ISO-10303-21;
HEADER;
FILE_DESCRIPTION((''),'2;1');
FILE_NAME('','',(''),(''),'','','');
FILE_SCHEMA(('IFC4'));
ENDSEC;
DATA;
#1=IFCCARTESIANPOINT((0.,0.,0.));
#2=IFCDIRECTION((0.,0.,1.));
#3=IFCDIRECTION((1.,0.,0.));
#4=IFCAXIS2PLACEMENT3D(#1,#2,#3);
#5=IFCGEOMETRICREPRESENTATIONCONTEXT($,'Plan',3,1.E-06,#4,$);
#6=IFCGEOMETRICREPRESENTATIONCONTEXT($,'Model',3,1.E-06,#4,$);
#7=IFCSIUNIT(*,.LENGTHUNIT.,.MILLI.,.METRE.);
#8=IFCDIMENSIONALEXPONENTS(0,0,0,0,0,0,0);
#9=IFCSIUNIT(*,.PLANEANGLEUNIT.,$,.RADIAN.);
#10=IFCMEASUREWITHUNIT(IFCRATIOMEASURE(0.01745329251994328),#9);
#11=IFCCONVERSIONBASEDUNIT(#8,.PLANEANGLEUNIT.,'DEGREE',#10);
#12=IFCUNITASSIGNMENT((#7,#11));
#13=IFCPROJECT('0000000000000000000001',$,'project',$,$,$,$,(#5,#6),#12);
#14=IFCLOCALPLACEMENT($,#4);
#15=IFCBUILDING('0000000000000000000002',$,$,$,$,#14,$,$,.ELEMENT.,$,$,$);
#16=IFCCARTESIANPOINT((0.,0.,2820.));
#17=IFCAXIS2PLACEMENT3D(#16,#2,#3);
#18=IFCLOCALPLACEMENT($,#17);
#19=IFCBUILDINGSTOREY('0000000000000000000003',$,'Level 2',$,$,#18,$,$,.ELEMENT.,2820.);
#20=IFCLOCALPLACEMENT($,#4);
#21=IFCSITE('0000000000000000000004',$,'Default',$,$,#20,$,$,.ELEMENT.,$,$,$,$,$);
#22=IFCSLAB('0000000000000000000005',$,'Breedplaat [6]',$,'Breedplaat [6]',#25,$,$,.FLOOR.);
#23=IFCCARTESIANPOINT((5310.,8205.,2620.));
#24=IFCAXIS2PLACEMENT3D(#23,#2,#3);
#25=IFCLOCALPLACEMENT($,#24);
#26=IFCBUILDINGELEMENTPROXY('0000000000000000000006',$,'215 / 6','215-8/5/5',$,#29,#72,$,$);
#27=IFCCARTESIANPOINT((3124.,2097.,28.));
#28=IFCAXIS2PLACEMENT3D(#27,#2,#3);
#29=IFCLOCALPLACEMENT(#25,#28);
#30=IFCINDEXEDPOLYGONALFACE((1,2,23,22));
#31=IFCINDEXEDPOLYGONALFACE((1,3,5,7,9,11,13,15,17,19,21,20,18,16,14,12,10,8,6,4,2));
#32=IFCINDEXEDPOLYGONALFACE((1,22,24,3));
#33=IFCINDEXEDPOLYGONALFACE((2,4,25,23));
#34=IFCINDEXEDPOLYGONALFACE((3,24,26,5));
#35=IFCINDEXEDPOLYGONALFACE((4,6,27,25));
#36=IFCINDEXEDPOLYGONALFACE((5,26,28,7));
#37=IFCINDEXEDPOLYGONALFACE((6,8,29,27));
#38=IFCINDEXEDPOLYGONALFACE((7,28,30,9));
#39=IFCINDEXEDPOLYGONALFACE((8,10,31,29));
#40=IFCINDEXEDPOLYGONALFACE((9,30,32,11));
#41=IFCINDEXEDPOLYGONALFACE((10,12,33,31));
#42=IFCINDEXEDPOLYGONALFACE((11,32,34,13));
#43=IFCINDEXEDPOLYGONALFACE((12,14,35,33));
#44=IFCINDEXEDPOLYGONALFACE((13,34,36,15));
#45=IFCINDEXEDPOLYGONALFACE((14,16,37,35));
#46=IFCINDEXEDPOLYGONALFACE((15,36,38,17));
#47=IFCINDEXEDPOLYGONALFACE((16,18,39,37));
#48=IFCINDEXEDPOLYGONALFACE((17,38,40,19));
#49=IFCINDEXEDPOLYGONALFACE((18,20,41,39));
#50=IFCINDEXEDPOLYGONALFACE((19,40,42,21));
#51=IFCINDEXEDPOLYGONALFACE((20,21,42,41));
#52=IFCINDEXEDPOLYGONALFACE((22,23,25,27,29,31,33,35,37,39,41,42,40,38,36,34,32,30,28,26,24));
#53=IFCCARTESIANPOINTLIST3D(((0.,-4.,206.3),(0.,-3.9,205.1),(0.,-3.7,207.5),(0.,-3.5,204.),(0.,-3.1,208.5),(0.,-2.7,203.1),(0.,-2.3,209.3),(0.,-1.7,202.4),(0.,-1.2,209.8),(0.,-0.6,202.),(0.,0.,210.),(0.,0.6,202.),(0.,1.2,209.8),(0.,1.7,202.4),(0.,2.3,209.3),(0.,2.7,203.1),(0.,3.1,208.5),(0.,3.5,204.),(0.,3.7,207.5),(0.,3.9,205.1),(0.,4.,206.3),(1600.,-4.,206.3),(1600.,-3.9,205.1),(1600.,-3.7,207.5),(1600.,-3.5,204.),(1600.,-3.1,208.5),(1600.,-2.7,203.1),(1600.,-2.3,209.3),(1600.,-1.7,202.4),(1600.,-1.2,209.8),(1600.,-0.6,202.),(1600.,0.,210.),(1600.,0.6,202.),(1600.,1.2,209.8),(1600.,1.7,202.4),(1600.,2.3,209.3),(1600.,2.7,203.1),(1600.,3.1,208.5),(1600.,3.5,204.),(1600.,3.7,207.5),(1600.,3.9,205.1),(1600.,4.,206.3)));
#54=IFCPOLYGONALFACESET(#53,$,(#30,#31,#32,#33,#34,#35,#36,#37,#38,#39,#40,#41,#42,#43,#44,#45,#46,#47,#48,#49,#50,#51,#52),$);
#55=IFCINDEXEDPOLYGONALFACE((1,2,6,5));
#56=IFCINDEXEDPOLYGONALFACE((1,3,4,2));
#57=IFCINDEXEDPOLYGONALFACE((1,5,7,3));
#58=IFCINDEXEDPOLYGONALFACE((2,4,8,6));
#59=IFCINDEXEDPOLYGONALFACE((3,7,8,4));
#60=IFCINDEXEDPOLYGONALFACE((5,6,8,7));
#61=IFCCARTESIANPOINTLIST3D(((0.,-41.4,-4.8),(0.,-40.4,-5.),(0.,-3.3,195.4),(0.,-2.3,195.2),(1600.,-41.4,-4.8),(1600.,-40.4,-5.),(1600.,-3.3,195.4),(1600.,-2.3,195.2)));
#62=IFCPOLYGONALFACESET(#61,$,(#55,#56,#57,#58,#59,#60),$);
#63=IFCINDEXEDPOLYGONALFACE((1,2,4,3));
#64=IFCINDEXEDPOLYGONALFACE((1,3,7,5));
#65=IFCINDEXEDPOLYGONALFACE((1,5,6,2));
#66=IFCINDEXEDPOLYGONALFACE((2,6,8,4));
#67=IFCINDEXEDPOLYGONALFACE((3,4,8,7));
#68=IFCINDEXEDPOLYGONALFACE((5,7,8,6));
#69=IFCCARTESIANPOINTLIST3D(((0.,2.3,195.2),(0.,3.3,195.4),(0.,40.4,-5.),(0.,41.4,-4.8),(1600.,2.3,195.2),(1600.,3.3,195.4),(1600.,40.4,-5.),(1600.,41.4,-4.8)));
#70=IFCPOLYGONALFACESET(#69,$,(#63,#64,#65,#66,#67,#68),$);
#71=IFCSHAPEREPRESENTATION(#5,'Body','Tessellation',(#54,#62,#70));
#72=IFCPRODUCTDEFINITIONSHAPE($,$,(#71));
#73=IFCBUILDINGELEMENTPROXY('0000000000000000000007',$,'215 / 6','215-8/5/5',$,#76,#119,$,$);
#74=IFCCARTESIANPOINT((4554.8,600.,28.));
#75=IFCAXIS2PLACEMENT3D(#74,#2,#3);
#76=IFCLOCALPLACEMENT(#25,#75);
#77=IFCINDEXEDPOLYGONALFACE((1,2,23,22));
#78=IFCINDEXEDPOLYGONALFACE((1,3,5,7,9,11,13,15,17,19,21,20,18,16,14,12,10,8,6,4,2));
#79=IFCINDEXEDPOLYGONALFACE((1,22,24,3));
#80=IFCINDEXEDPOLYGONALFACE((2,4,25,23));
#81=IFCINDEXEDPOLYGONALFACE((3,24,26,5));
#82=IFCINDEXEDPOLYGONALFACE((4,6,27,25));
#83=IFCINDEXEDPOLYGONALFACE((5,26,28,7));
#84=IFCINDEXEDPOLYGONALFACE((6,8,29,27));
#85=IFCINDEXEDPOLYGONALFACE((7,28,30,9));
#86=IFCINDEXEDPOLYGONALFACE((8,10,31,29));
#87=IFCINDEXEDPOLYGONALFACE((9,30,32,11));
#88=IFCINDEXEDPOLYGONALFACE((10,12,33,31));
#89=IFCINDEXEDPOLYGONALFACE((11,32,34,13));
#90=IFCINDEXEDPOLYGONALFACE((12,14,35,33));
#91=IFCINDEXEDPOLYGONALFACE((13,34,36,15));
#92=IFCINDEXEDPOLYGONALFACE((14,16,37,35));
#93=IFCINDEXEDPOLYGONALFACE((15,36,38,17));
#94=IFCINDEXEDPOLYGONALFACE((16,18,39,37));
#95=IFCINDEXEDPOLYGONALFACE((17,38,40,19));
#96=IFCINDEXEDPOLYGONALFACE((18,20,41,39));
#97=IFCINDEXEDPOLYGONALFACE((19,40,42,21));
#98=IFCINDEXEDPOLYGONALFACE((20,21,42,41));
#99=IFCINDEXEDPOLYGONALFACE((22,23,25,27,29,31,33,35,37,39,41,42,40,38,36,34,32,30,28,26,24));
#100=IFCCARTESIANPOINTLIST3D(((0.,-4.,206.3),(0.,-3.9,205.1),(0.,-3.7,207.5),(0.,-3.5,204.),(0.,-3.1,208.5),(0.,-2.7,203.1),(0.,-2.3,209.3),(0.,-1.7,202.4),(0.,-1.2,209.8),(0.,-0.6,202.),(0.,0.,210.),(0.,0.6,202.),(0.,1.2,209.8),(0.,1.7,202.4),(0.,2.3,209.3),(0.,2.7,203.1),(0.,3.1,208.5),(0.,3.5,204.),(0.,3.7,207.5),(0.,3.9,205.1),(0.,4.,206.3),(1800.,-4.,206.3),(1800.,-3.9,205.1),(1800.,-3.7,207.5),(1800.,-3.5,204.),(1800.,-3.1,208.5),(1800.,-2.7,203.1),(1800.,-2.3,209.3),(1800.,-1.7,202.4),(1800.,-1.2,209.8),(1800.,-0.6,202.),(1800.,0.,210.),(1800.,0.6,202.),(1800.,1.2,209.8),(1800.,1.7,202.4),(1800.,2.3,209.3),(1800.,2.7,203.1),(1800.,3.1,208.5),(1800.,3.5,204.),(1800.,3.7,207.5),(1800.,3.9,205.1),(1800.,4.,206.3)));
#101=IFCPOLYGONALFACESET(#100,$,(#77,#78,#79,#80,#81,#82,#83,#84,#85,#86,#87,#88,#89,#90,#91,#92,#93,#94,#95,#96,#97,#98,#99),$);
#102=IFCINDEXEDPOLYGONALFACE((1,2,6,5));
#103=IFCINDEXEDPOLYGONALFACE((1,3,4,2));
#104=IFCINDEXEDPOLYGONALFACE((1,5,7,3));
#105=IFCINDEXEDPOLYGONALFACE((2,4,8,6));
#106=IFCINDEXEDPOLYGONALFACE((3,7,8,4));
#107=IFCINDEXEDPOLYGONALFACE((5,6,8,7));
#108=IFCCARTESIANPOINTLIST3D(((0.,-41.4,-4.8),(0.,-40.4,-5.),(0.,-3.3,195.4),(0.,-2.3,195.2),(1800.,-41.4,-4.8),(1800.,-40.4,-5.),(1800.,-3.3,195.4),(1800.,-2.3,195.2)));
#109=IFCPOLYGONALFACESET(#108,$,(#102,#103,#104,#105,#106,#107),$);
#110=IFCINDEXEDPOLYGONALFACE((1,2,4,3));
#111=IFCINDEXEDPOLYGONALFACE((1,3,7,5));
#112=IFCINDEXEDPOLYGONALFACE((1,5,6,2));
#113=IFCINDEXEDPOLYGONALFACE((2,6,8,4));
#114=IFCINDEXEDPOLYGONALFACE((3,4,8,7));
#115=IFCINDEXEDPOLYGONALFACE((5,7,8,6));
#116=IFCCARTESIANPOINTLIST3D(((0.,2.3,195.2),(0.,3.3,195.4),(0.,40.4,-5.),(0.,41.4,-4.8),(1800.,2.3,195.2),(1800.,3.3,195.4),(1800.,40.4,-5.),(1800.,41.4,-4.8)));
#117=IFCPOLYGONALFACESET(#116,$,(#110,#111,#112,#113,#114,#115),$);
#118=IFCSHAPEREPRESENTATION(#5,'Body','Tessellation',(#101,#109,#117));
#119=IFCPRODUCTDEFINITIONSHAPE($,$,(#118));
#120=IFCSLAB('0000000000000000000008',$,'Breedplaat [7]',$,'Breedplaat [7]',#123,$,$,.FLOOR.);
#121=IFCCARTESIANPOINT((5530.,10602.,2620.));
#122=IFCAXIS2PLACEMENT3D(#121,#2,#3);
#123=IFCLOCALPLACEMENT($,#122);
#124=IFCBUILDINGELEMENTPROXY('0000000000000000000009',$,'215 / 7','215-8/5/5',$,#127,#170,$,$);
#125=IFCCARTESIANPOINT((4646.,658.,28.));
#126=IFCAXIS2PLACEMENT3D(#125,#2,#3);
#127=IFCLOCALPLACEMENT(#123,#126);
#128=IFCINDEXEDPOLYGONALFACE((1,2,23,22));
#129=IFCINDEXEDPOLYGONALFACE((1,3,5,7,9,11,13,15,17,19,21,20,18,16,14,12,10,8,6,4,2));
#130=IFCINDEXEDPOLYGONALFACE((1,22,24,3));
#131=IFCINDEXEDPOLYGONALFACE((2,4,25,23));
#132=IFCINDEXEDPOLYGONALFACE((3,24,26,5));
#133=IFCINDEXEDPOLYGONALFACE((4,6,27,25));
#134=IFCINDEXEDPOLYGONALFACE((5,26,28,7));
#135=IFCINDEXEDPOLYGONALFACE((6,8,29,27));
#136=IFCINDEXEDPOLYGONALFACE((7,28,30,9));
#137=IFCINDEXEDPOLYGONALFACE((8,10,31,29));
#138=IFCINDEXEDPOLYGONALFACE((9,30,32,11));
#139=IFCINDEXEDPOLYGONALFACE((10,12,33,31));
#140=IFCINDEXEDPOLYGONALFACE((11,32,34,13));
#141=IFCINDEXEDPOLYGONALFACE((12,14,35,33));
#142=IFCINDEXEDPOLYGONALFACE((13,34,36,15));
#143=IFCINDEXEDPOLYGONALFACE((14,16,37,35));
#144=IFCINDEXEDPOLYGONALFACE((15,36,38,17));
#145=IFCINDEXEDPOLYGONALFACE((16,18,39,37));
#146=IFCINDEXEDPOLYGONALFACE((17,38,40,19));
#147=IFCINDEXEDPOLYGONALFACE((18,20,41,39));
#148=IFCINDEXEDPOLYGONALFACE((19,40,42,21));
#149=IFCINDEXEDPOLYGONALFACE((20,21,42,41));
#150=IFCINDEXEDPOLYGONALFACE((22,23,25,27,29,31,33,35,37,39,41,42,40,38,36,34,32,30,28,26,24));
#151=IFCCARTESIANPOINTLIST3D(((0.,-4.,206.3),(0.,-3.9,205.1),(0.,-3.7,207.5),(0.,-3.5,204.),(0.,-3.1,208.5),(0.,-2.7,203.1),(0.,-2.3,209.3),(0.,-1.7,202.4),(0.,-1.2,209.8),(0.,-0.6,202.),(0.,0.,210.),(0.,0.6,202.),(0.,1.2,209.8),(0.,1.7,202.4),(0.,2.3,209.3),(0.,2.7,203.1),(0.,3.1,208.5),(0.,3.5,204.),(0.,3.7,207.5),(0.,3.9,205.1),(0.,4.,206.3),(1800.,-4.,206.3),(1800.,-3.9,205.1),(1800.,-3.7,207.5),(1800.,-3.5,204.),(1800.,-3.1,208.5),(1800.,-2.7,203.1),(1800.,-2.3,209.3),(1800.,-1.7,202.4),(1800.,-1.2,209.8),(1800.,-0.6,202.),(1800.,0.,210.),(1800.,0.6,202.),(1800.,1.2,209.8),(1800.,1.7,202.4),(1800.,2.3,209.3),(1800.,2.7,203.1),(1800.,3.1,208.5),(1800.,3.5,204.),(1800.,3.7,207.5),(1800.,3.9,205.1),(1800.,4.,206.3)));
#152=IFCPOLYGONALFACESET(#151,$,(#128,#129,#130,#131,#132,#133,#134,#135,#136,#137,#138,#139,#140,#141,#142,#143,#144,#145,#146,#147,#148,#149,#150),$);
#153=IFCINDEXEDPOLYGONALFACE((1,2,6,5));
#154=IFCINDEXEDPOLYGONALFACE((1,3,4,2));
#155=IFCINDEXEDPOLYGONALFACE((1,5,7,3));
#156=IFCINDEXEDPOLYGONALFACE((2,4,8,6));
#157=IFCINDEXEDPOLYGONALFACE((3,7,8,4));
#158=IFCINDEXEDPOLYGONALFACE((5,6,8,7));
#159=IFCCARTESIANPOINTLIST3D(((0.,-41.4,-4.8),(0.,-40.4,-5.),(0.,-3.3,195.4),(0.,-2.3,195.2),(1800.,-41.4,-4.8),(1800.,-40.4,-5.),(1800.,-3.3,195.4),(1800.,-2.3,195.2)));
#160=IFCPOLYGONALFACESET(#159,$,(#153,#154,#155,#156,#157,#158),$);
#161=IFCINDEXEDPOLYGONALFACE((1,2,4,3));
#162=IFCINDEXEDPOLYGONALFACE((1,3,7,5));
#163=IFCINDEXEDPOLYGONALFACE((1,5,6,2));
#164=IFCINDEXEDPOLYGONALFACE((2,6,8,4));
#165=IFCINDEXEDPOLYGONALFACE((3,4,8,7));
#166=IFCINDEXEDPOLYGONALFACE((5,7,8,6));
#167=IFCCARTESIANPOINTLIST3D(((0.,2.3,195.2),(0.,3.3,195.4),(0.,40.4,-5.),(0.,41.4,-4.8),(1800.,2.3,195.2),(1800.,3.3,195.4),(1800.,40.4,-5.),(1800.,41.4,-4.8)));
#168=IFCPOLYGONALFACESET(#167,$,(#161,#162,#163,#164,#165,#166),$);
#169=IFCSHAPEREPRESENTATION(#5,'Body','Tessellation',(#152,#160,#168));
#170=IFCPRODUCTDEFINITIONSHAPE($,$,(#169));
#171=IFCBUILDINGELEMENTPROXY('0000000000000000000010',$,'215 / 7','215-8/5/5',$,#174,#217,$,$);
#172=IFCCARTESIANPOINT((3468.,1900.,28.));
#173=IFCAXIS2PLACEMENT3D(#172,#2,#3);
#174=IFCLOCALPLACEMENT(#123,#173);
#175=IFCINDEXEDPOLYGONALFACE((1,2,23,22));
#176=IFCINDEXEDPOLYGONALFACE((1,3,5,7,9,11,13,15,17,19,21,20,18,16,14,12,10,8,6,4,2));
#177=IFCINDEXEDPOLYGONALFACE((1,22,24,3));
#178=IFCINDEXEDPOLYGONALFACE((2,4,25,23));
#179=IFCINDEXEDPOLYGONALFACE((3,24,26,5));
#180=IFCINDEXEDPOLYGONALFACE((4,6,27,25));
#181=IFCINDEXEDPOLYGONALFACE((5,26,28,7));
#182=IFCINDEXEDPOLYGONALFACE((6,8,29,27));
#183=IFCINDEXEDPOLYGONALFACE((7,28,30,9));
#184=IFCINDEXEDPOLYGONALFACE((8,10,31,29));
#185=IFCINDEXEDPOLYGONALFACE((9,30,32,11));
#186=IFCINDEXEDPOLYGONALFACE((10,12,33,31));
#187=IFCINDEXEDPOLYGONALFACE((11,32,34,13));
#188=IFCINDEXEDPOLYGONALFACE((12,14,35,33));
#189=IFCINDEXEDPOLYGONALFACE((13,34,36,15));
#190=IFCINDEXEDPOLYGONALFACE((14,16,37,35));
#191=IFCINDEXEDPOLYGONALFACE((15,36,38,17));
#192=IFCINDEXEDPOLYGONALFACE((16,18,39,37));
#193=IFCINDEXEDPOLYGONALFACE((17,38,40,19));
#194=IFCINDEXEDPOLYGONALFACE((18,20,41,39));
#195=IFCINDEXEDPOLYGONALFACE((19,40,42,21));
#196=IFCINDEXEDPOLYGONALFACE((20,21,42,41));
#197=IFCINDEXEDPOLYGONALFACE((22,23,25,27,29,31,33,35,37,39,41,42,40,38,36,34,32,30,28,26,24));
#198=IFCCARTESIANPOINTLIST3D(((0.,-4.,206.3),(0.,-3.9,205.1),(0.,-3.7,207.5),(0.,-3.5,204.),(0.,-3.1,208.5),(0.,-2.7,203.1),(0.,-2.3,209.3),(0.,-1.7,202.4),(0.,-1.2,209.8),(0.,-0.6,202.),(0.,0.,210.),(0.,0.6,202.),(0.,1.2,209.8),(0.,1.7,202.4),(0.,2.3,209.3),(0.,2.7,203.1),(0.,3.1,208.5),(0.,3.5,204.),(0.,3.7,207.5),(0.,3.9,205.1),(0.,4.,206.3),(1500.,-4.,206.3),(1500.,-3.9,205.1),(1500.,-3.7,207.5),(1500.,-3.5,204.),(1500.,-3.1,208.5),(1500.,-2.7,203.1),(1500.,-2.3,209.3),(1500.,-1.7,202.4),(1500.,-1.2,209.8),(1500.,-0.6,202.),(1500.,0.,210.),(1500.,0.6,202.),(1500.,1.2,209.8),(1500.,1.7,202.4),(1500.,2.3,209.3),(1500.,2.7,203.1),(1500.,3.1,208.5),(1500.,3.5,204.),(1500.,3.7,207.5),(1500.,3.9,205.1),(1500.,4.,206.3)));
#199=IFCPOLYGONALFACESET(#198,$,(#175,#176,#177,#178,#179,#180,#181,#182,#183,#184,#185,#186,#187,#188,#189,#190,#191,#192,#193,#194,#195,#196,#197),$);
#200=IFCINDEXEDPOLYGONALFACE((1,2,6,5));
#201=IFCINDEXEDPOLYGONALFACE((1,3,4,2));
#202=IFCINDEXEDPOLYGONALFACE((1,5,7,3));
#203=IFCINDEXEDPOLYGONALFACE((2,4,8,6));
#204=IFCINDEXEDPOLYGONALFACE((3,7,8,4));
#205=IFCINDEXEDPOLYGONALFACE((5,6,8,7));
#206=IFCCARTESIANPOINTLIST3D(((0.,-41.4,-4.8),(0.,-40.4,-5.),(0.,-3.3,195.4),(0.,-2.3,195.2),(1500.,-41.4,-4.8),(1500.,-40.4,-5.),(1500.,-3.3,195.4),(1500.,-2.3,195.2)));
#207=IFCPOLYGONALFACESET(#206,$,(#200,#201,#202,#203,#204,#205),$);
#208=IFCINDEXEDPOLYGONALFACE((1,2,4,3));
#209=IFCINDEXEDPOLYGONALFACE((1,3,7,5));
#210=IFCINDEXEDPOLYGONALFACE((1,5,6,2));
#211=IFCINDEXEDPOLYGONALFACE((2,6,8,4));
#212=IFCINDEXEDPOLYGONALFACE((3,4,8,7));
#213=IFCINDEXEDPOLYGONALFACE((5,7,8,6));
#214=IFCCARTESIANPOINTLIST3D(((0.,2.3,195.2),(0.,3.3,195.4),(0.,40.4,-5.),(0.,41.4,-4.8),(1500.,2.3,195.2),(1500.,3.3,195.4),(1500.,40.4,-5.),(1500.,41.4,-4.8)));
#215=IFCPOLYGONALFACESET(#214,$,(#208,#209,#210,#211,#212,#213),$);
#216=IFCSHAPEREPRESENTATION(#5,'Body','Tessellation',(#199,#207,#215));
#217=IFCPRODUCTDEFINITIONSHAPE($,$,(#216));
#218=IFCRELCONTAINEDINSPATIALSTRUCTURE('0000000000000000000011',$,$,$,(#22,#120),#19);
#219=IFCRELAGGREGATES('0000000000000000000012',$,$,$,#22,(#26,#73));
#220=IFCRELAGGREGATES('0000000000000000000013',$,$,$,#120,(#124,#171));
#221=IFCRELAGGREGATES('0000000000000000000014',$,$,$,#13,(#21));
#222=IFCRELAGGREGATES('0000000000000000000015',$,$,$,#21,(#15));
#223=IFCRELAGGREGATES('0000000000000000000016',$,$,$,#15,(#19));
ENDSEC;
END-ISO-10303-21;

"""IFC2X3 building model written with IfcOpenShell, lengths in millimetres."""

from ifc_helpers import new_model, entity, si_unit, converted_unit, frame, origin_with_axes, origin_2d_with_axis, place, context, project, spatial, rectangle, circle, extrude, element, aggregate, save


model = new_model("IFC2X3")

# Units and contexts
plan_context = context("Plan", 3, precision=1e-06, world=origin_with_axes())
model_context = context("Model", 3, precision=1e-06, world=origin_with_axes())
ifc_project = project(units=[si_unit("LENGTHUNIT", "METRE", prefix="MILLI"), converted_unit("PLANEANGLEUNIT", "DEGREE", entity("IfcRatioMeasure", 0.01745329251994328), si_unit("PLANEANGLEUNIT", "RADIAN"), dimensions=[0, 0, 0, 0, 0, 0, 0])], contexts=[plan_context, model_context])

# Site, building, storey
site_placement = place(None, origin_with_axes())
site = spatial("IfcSite", under=ifc_project, at=site_placement, Name="Default", CompositionType="ELEMENT")
building_placement = place(None, origin_with_axes())
building = spatial("IfcBuilding", under=site, at=building_placement, CompositionType="ELEMENT")
storey_placement = place(None, frame((0.0, 0.0, 2820.0), z_axis=(0.0, 0.0, 1.0), x_axis=(1.0, 0.0, 0.0)))
storey = spatial("IfcBuildingStorey", under=building, at=storey_placement, Name="Level 2", CompositionType="ELEMENT", Elevation=2820.0)

# Slabs, building element proxies
slab_1_placement = place(None, frame((5310.0, 8205.0, 2620.0), z_axis=(0.0, 0.0, 1.0), x_axis=(1.0, 0.0, 0.0)))
slab_1 = element("IfcSlab", 1, at=slab_1_placement, inside=storey, Name="Breedplaat [6]", ObjectType="Breedplaat [6]", PredefinedType="FLOOR")
proxy_1_placement = place(slab_1_placement, frame((3124.0, 2097.0, 28.0), z_axis=(0.0, 0.0, 1.0), x_axis=(1.0, 0.0, 0.0)))
proxy_1 = element("IfcBuildingElementProxy", 2, at=proxy_1_placement, Name="215 / 6", Description="215-8/5/5", context=plan_context, shape_type="SweptSolid", body=[
    extrude(circle(Radius=4.0, at=origin_2d_with_axis()), frame((0.0, 0.0, 206.0), z_axis=(1.0, 0.0, 0.0), x_axis=(0.0, 0.0, 1.0)), (0.0, 0.0, 1.0), 1600.0),
    extrude(rectangle(XDim=203.8, YDim=1.0, at=origin_2d_with_axis()), frame((0.0, -21.9, 95.2), z_axis=(1.0, 0.0, 0.0), x_axis=(0.0, 0.187112, 0.982339)), (0.0, 0.0, 1.0), 1600.0),
    extrude(rectangle(XDim=203.8, YDim=1.0, at=origin_2d_with_axis()), frame((0.0, 21.9, 95.2), z_axis=(1.0, 0.0, 0.0), x_axis=(0.0, -0.187112, 0.982339)), (0.0, 0.0, 1.0), 1600.0),
])
proxy_2_placement = place(slab_1_placement, frame((4554.8, 600.0, 28.0), z_axis=(0.0, 0.0, 1.0), x_axis=(1.0, 0.0, 0.0)))
proxy_2 = element("IfcBuildingElementProxy", 3, at=proxy_2_placement, Name="215 / 6", Description="215-8/5/5", context=plan_context, shape_type="SweptSolid", body=[
    extrude(circle(Radius=4.0, at=origin_2d_with_axis()), frame((0.0, 0.0, 206.0), z_axis=(1.0, 0.0, 0.0), x_axis=(0.0, 0.0, 1.0)), (0.0, 0.0, 1.0), 1800.0),
    extrude(rectangle(XDim=203.8, YDim=1.0, at=origin_2d_with_axis()), frame((0.0, -21.9, 95.2), z_axis=(1.0, 0.0, 0.0), x_axis=(0.0, 0.187112, 0.982339)), (0.0, 0.0, 1.0), 1800.0),
    extrude(rectangle(XDim=203.8, YDim=1.0, at=origin_2d_with_axis()), frame((0.0, 21.9, 95.2), z_axis=(1.0, 0.0, 0.0), x_axis=(0.0, -0.187112, 0.982339)), (0.0, 0.0, 1.0), 1800.0),
])
aggregate(slab_1, [proxy_1, proxy_2])
slab_2_placement = place(None, frame((5530.0, 10602.0, 2620.0), z_axis=(0.0, 0.0, 1.0), x_axis=(1.0, 0.0, 0.0)))
slab_2 = element("IfcSlab", 4, at=slab_2_placement, inside=storey, Name="Breedplaat [7]", ObjectType="Breedplaat [7]", PredefinedType="FLOOR")
proxy_3_placement = place(slab_2_placement, frame((4646.0, 658.0, 28.0), z_axis=(0.0, 0.0, 1.0), x_axis=(1.0, 0.0, 0.0)))
proxy_3 = element("IfcBuildingElementProxy", 5, at=proxy_3_placement, Name="215 / 7", Description="215-8/5/5", context=plan_context, shape_type="SweptSolid", body=[
    extrude(circle(Radius=4.0, at=origin_2d_with_axis()), frame((0.0, 0.0, 206.0), z_axis=(1.0, 0.0, 0.0), x_axis=(0.0, 0.0, 1.0)), (0.0, 0.0, 1.0), 1800.0),
    extrude(rectangle(XDim=203.8, YDim=1.0, at=origin_2d_with_axis()), frame((0.0, -21.9, 95.2), z_axis=(1.0, 0.0, 0.0), x_axis=(0.0, 0.187112, 0.982339)), (0.0, 0.0, 1.0), 1800.0),
    extrude(rectangle(XDim=203.8, YDim=1.0, at=origin_2d_with_axis()), frame((0.0, 21.9, 95.2), z_axis=(1.0, 0.0, 0.0), x_axis=(0.0, -0.187112, 0.982339)), (0.0, 0.0, 1.0), 1800.0),
])
proxy_4_placement = place(slab_2_placement, frame((3468.0, 1900.0, 28.0), z_axis=(0.0, 0.0, 1.0), x_axis=(1.0, 0.0, 0.0)))
proxy_4 = element("IfcBuildingElementProxy", 6, at=proxy_4_placement, Name="215 / 7", Description="215-8/5/5", context=plan_context, shape_type="SweptSolid", body=[
    extrude(circle(Radius=4.0, at=origin_2d_with_axis()), frame((0.0, 0.0, 206.0), z_axis=(1.0, 0.0, 0.0), x_axis=(0.0, 0.0, 1.0)), (0.0, 0.0, 1.0), 1500.0),
    extrude(rectangle(XDim=203.8, YDim=1.0, at=origin_2d_with_axis()), frame((0.0, -21.9, 95.2), z_axis=(1.0, 0.0, 0.0), x_axis=(0.0, 0.187112, 0.982339)), (0.0, 0.0, 1.0), 1500.0),
    extrude(rectangle(XDim=203.8, YDim=1.0, at=origin_2d_with_axis()), frame((0.0, 21.9, 95.2), z_axis=(1.0, 0.0, 0.0), x_axis=(0.0, -0.187112, 0.982339)), (0.0, 0.0, 1.0), 1500.0),
])
aggregate(slab_2, [proxy_3, proxy_4])

save(model, "model.ifc")
